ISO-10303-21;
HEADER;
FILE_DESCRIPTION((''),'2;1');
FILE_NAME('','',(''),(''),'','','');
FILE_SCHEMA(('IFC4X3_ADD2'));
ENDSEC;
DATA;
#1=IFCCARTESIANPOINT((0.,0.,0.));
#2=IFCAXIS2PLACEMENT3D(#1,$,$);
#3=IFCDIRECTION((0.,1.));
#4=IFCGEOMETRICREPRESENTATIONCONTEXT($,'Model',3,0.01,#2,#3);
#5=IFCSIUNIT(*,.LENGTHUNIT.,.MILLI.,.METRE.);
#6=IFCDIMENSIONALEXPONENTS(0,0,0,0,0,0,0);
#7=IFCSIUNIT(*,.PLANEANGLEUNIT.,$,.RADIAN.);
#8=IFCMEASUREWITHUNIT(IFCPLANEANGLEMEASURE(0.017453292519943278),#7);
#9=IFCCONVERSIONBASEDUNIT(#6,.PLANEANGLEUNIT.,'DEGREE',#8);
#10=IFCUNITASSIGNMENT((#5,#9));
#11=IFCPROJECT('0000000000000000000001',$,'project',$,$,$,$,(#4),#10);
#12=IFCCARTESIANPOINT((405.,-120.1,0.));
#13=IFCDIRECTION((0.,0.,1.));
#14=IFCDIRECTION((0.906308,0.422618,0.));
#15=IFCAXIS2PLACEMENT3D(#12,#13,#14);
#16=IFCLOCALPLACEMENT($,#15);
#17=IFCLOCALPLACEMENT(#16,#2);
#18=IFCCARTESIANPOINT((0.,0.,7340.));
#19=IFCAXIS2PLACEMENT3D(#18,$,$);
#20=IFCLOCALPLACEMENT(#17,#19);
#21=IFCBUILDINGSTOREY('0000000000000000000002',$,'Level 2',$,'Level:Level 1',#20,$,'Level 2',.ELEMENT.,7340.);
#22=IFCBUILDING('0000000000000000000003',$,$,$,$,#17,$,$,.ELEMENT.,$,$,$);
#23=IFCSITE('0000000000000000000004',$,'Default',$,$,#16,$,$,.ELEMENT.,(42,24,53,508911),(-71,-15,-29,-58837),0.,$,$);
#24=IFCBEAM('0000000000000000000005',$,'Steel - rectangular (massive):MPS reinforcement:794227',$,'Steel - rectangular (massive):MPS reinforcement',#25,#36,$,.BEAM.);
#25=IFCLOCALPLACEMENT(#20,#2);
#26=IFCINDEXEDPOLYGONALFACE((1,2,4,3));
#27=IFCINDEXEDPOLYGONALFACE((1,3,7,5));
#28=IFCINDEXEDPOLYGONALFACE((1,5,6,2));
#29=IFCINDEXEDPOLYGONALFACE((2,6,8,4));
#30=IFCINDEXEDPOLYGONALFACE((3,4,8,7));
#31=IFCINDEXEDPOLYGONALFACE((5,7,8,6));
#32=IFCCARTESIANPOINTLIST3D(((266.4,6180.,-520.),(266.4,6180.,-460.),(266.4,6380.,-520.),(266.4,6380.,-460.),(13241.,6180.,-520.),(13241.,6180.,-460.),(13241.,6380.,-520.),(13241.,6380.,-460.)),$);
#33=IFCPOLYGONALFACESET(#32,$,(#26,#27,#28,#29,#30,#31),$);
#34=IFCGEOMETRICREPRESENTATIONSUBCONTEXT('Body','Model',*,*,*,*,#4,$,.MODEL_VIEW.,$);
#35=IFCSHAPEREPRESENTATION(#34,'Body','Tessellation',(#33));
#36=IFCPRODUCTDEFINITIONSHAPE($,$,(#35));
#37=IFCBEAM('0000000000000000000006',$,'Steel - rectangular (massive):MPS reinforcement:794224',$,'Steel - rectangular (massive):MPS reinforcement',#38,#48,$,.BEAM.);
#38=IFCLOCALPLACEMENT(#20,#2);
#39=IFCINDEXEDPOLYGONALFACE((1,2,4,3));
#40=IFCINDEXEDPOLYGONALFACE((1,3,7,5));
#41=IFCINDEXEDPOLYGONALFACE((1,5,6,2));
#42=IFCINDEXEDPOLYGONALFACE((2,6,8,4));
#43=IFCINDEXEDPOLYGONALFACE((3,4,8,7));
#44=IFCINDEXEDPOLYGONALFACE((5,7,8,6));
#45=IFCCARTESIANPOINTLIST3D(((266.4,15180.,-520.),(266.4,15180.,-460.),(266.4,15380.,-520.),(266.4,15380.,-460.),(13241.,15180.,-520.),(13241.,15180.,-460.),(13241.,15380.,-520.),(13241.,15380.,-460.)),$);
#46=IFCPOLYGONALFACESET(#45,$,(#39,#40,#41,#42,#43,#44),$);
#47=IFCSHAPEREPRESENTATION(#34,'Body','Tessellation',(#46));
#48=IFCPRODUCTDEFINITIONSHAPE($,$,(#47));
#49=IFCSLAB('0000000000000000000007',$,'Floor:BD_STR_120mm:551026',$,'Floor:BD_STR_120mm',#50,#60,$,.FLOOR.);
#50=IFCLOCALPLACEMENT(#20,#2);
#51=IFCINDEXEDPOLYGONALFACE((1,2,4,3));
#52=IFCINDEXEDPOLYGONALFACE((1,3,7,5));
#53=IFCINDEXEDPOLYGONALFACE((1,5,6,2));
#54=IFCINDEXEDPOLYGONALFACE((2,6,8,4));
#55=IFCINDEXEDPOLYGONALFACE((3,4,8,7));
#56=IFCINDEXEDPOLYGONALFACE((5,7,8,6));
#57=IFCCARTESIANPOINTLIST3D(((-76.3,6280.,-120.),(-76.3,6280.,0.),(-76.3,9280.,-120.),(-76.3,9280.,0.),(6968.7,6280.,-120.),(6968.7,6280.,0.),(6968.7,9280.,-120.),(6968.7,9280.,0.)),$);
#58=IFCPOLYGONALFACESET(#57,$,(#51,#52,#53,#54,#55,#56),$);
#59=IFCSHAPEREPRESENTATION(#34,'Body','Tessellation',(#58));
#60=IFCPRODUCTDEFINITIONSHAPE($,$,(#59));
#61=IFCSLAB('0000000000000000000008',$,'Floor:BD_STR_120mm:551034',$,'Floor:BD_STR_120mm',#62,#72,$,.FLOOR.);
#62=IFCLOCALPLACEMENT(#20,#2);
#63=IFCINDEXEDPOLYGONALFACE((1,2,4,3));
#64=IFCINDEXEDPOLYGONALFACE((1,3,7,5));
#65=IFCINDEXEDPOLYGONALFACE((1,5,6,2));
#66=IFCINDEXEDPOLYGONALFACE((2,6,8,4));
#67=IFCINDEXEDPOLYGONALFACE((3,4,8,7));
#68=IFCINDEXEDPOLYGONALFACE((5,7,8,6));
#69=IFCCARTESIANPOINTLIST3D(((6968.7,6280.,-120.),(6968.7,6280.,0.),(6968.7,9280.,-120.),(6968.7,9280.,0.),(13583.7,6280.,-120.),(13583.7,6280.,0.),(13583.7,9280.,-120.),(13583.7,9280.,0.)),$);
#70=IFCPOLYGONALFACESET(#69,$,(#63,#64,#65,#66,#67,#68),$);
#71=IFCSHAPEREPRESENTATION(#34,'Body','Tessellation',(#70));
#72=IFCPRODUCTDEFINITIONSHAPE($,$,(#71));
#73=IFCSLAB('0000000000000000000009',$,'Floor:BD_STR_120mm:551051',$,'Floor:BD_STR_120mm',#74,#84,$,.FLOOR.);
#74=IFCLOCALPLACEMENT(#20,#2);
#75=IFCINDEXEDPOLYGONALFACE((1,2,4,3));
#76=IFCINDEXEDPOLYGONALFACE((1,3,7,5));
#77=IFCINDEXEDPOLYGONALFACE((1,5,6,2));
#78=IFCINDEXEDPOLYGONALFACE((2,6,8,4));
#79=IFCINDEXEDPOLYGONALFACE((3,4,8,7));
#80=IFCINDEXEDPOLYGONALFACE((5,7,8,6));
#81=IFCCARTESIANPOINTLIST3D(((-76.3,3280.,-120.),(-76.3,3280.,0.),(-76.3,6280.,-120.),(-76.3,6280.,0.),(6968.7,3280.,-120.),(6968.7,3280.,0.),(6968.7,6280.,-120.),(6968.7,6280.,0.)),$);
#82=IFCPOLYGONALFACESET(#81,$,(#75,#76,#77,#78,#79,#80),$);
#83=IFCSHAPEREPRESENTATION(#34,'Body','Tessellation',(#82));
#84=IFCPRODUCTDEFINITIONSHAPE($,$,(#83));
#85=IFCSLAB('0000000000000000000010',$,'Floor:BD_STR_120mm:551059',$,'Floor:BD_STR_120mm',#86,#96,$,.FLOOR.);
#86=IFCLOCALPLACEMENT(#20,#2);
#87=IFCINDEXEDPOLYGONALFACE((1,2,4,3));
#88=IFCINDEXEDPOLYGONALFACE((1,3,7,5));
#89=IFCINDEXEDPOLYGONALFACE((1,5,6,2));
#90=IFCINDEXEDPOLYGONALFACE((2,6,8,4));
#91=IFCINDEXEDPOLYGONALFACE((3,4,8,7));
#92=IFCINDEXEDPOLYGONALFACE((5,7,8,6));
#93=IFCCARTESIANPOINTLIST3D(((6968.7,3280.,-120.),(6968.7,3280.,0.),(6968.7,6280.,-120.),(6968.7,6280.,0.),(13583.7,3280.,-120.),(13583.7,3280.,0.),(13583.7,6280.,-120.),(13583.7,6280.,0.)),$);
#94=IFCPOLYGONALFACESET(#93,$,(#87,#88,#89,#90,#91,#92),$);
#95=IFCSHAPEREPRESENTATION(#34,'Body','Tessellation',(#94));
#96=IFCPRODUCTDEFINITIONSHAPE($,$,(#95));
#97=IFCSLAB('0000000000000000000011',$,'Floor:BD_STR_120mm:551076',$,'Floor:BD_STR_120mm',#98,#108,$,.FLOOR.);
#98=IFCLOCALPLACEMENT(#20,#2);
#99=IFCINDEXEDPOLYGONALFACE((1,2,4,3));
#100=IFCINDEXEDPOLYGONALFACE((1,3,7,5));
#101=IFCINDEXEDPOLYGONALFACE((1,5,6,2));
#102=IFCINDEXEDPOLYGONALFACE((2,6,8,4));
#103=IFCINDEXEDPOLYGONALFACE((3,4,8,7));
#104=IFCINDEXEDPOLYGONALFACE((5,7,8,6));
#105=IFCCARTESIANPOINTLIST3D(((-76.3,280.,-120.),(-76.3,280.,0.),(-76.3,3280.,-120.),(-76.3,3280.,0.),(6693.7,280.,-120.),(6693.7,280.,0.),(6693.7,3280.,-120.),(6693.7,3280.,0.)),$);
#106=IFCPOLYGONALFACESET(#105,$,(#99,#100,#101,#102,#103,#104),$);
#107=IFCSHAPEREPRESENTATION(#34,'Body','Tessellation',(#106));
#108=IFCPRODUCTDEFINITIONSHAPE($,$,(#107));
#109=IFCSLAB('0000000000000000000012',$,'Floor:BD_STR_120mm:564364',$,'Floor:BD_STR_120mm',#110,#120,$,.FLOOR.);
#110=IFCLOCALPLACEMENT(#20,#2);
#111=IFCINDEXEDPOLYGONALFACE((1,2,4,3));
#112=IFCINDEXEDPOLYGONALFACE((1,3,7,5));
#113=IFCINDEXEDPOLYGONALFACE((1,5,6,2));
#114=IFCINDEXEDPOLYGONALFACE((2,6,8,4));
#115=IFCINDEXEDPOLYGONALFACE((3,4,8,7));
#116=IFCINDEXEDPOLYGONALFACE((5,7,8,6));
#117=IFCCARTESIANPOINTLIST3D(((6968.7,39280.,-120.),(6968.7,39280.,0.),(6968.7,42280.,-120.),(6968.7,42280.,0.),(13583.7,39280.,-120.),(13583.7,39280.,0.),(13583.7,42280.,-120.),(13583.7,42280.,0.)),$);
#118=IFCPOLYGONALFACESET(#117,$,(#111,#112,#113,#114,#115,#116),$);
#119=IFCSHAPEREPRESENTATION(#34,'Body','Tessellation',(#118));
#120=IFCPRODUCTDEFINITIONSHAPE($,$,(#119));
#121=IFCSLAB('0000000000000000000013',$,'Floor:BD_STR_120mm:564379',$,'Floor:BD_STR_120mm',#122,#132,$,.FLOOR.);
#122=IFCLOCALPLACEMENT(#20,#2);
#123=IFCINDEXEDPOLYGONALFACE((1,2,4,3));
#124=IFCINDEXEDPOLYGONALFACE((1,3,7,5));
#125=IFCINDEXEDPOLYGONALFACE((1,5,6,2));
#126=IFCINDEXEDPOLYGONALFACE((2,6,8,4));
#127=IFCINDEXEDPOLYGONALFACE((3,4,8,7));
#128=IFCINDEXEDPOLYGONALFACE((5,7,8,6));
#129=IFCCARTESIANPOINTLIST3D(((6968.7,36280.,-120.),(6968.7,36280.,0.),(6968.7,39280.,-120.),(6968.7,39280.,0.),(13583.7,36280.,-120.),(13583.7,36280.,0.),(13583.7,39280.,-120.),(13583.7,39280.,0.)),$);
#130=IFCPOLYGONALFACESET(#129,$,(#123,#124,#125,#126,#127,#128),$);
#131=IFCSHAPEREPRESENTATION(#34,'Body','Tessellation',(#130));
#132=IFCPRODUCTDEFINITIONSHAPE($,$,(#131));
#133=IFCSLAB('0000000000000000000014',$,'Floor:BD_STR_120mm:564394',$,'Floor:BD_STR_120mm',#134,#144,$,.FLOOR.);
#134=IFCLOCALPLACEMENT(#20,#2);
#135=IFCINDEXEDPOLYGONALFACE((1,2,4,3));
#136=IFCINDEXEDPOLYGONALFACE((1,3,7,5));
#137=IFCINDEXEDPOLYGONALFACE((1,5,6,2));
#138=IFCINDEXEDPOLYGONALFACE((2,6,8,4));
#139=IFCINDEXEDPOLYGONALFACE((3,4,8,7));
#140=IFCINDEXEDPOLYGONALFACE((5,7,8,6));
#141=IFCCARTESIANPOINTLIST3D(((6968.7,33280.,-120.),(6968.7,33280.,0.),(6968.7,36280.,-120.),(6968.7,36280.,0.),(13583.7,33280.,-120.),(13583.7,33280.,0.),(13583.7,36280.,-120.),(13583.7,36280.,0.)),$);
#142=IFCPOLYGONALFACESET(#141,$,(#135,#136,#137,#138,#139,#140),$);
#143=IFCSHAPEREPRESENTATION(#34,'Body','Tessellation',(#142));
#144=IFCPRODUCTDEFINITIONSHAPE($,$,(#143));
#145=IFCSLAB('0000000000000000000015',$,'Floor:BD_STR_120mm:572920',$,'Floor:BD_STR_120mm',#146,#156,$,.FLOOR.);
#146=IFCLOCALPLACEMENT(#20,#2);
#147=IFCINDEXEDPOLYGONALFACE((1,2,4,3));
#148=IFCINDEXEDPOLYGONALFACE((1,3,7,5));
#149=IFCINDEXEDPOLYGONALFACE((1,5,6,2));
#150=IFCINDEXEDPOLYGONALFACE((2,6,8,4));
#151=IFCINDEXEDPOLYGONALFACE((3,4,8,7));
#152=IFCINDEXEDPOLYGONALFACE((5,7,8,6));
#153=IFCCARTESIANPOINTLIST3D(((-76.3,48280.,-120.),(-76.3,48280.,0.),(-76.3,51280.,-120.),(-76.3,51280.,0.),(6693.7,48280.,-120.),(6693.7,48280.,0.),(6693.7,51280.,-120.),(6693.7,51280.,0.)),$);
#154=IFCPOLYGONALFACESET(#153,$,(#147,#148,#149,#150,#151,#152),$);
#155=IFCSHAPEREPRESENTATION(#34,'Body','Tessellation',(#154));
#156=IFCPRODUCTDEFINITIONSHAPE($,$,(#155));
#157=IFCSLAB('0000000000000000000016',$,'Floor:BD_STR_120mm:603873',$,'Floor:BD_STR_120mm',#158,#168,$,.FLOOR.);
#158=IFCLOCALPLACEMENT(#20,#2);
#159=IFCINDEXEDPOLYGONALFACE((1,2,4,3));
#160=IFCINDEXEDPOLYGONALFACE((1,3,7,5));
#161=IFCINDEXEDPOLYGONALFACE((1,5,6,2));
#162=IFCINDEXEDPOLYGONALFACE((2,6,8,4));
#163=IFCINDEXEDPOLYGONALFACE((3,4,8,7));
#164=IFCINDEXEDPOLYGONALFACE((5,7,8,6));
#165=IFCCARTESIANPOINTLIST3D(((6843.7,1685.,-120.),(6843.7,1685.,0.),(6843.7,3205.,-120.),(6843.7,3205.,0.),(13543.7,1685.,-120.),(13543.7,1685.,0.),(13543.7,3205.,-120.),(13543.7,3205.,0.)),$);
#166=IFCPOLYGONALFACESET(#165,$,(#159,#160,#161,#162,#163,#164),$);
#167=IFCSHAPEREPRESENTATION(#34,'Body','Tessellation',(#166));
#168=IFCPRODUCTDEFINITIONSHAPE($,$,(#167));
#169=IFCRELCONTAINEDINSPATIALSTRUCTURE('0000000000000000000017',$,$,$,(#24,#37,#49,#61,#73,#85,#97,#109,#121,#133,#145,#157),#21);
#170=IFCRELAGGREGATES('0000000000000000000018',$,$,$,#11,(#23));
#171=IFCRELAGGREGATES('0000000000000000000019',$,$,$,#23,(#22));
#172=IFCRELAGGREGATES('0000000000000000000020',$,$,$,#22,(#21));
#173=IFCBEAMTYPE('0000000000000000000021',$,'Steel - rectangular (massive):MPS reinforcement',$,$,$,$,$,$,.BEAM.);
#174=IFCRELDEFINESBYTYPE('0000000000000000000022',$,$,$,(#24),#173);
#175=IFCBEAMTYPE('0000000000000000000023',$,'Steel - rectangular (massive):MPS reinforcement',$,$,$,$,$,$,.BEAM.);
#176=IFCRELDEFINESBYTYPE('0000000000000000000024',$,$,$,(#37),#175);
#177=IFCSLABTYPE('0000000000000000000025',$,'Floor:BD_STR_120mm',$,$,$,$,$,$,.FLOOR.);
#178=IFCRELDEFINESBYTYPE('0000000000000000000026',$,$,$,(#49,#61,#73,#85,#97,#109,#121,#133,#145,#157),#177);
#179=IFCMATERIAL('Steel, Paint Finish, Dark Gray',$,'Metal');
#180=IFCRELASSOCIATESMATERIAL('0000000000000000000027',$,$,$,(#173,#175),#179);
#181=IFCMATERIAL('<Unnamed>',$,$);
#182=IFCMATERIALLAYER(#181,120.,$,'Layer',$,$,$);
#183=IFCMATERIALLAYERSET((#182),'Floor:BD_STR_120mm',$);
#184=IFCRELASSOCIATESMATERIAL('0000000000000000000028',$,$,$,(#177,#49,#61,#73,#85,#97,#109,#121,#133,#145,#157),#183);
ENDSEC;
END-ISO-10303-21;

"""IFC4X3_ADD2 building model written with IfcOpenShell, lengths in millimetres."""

from ifc_helpers import new_model, entity, si_unit, converted_unit, direction, frame, frame_2d, origin, origin_2d_with_axis, place, context, subcontext, project, spatial, rectangle, extrude, source, transform, mapped, material, layer, layer_set, layer_usage, material_profile, profile_set, type_object, type_shapes, element, save


model = new_model("IFC4X3_ADD2")

# Units and contexts
model_context = context("Model", 3, precision=0.01, world=origin(), true_north=direction((0.0, 1.0)))
body_context = subcontext(model_context, "Body", "Model", "MODEL_VIEW")
ifc_project = project(units=[si_unit("LENGTHUNIT", "METRE", prefix="MILLI"), converted_unit("PLANEANGLEUNIT", "DEGREE", entity("IfcPlaneAngleMeasure", 0.017453292519943278), si_unit("PLANEANGLEUNIT", "RADIAN"), dimensions=[0, 0, 0, 0, 0, 0, 0])], contexts=[model_context])

# Site, building, storey
site_placement = place(None, frame((405.0, -120.1, 0.0), z_axis=(0.0, 0.0, 1.0), x_axis=(0.906308, 0.422618, 0.0)))
site = spatial("IfcSite", under=ifc_project, at=site_placement, Name="Default", CompositionType="ELEMENT", RefLatitude=(42, 24, 53, 508911), RefLongitude=(-71, -15, -29, -58837), RefElevation=0.0)
building_placement = place(site_placement, origin())
building = spatial("IfcBuilding", under=site, at=building_placement, CompositionType="ELEMENT")
storey_placement = place(building_placement, frame((0.0, 0.0, 7340.0)))
storey = spatial("IfcBuildingStorey", under=building, at=storey_placement, Name="Level 2", ObjectType="Level:Level 1", LongName="Level 2", CompositionType="ELEMENT", Elevation=7340.0)

# Beams
ifc_material_1 = material(Name="Steel, Paint Finish, Dark Gray", Category="Metal")
ifc_material_profile_1 = material_profile(ifc_material_1, rectangle(XDim=12974.6, YDim=200.0, at=origin_2d_with_axis()), Name="MPS reinforcement")
ifc_profile_set_1 = profile_set([ifc_material_profile_1], Name="MPS reinforcement")
beam_type_1 = type_object("IfcBeamType", Name="Steel - rectangular (massive):MPS reinforcement", PredefinedType="BEAM", material=ifc_profile_set_1)
shared_shape_1 = source(origin(), body_context, "Body", "SweptSolid", [
    extrude(rectangle(XDim=12974.6, YDim=200.0, at=origin_2d_with_axis()), frame((0.0, 0.0, -30.0), z_axis=(0.0, 0.0, 1.0), x_axis=(-1.0, 0.0, 0.0)), (0.0, 0.0, 1.0), 60.0),
])
type_shapes(beam_type_1, [shared_shape_1])
beam_1_placement = place(storey_placement, frame((6753.7, 6280.0, -490.0), z_axis=(0.0, 0.0, 1.0), x_axis=(-1.0, 0.0, 0.0)))
element("IfcBeam", 1, at=beam_1_placement, inside=storey, type_object=beam_type_1, Name="Steel - rectangular (massive):MPS reinforcement:794227", ObjectType="Steel - rectangular (massive):MPS reinforcement", PredefinedType="BEAM", context=body_context, shape_type="MappedRepresentation", body=[
    mapped(shared_shape_1, transform((0.0, 0.0, 0.0), scale=1.0)),
])
beam_type_2 = type_object("IfcBeamType", Name="Steel - rectangular (massive):MPS reinforcement", PredefinedType="BEAM", material=ifc_profile_set_1)
shared_shape_2 = source(origin(), body_context, "Body", "SweptSolid", [
    extrude(rectangle(XDim=12974.6, YDim=200.0, at=origin_2d_with_axis()), frame((-0.5, 0.0, -30.0), z_axis=(0.0, 0.0, 1.0), x_axis=(-1.0, 0.0, 0.0)), (0.0, 0.0, 1.0), 60.0),
])
type_shapes(beam_type_2, [shared_shape_2])
beam_2_placement = place(storey_placement, frame((6754.2, 15280.0, -490.0)))
element("IfcBeam", 2, at=beam_2_placement, inside=storey, type_object=beam_type_2, Name="Steel - rectangular (massive):MPS reinforcement:794224", ObjectType="Steel - rectangular (massive):MPS reinforcement", PredefinedType="BEAM", context=body_context, shape_type="MappedRepresentation", body=[
    mapped(shared_shape_2, transform((0.0, 0.0, 0.0), scale=1.0)),
])

# Slabs
ifc_material_2 = material(Name="<Unnamed>")
ifc_layer_1 = layer(ifc_material_2, 120.0, Name="Layer")
ifc_layer_set_1 = layer_set([ifc_layer_1], Name="Floor:BD_STR_120mm")
ifc_layer_usage_1 = layer_usage(ifc_layer_set_1, "AXIS3", "POSITIVE", 0.0)
slab_type_1 = type_object("IfcSlabType", Name="Floor:BD_STR_120mm", PredefinedType="FLOOR", material=ifc_layer_set_1)
slab_1_placement = place(storey_placement, origin())
element("IfcSlab", 3, at=slab_1_placement, inside=storey, type_object=slab_type_1, material=ifc_layer_usage_1, Name="Floor:BD_STR_120mm:551026", ObjectType="Floor:BD_STR_120mm", PredefinedType="FLOOR", context=body_context, shape_type="SweptSolid", body=[
    extrude(rectangle(XDim=3000.0, YDim=7045.0, at=origin_2d_with_axis()), frame((3446.2, 7780.0, 0.0), z_axis=(0.0, 0.0, -1.0), x_axis=(0.0, 1.0, 0.0)), (0.0, 0.0, 1.0), 120.0),
])
ifc_layer_usage_2 = layer_usage(ifc_layer_set_1, "AXIS3", "POSITIVE", 0.0)
slab_2_placement = place(storey_placement, origin())
element("IfcSlab", 4, at=slab_2_placement, inside=storey, type_object=slab_type_1, material=ifc_layer_usage_2, Name="Floor:BD_STR_120mm:551034", ObjectType="Floor:BD_STR_120mm", PredefinedType="FLOOR", context=body_context, shape_type="SweptSolid", body=[
    extrude(rectangle(XDim=3000.0, YDim=6615.0, at=frame_2d((0.0, 0.0), x_axis=(1.0, 0.0))), frame((10276.2, 7780.0, 0.0), z_axis=(0.0, 0.0, -1.0), x_axis=(0.0, 1.0, 0.0)), (0.0, 0.0, 1.0), 120.0),
])
ifc_layer_usage_3 = layer_usage(ifc_layer_set_1, "AXIS3", "POSITIVE", 0.0)
slab_3_placement = place(storey_placement, origin())
element("IfcSlab", 5, at=slab_3_placement, inside=storey, type_object=slab_type_1, material=ifc_layer_usage_3, Name="Floor:BD_STR_120mm:551051", ObjectType="Floor:BD_STR_120mm", PredefinedType="FLOOR", context=body_context, shape_type="SweptSolid", body=[
    extrude(rectangle(XDim=3000.0, YDim=7045.0, at=origin_2d_with_axis()), frame((3446.2, 4780.0, 0.0), z_axis=(0.0, 0.0, -1.0), x_axis=(0.0, 1.0, 0.0)), (0.0, 0.0, 1.0), 120.0),
])
ifc_layer_usage_4 = layer_usage(ifc_layer_set_1, "AXIS3", "POSITIVE", 0.0)
slab_4_placement = place(storey_placement, origin())
element("IfcSlab", 6, at=slab_4_placement, inside=storey, type_object=slab_type_1, material=ifc_layer_usage_4, Name="Floor:BD_STR_120mm:551059", ObjectType="Floor:BD_STR_120mm", PredefinedType="FLOOR", context=body_context, shape_type="SweptSolid", body=[
    extrude(rectangle(XDim=3000.0, YDim=6615.0, at=frame_2d((0.0, 0.0), x_axis=(1.0, 0.0))), frame((10276.2, 4780.0, 0.0), z_axis=(0.0, 0.0, -1.0), x_axis=(0.0, 1.0, 0.0)), (0.0, 0.0, 1.0), 120.0),
])
ifc_layer_usage_5 = layer_usage(ifc_layer_set_1, "AXIS3", "POSITIVE", 0.0)
slab_5_placement = place(storey_placement, origin())
element("IfcSlab", 7, at=slab_5_placement, inside=storey, type_object=slab_type_1, material=ifc_layer_usage_5, Name="Floor:BD_STR_120mm:551076", ObjectType="Floor:BD_STR_120mm", PredefinedType="FLOOR", context=body_context, shape_type="SweptSolid", body=[
    extrude(rectangle(XDim=3000.0, YDim=6770.0, at=frame_2d((0.0, 0.0), x_axis=(1.0, 0.0))), frame((3308.7, 1780.0, 0.0), z_axis=(0.0, 0.0, -1.0), x_axis=(0.0, 1.0, 0.0)), (0.0, 0.0, 1.0), 120.0),
])
ifc_layer_usage_6 = layer_usage(ifc_layer_set_1, "AXIS3", "POSITIVE", 0.0)
slab_6_placement = place(storey_placement, origin())
element("IfcSlab", 8, at=slab_6_placement, inside=storey, type_object=slab_type_1, material=ifc_layer_usage_6, Name="Floor:BD_STR_120mm:564364", ObjectType="Floor:BD_STR_120mm", PredefinedType="FLOOR", context=body_context, shape_type="SweptSolid", body=[
    extrude(rectangle(XDim=3000.0, YDim=6615.0, at=frame_2d((0.0, 0.0), x_axis=(1.0, 0.0))), frame((10276.2, 40780.0, 0.0), z_axis=(0.0, 0.0, -1.0), x_axis=(0.0, 1.0, 0.0)), (0.0, 0.0, 1.0), 120.0),
])
ifc_layer_usage_7 = layer_usage(ifc_layer_set_1, "AXIS3", "POSITIVE", 0.0)
slab_7_placement = place(storey_placement, origin())
element("IfcSlab", 9, at=slab_7_placement, inside=storey, type_object=slab_type_1, material=ifc_layer_usage_7, Name="Floor:BD_STR_120mm:564379", ObjectType="Floor:BD_STR_120mm", PredefinedType="FLOOR", context=body_context, shape_type="SweptSolid", body=[
    extrude(rectangle(XDim=3000.0, YDim=6615.0, at=frame_2d((0.0, 0.0), x_axis=(1.0, 0.0))), frame((10276.2, 37780.0, 0.0), z_axis=(0.0, 0.0, -1.0), x_axis=(0.0, 1.0, 0.0)), (0.0, 0.0, 1.0), 120.0),
])
ifc_layer_usage_8 = layer_usage(ifc_layer_set_1, "AXIS3", "POSITIVE", 0.0)
slab_8_placement = place(storey_placement, origin())
element("IfcSlab", 10, at=slab_8_placement, inside=storey, type_object=slab_type_1, material=ifc_layer_usage_8, Name="Floor:BD_STR_120mm:564394", ObjectType="Floor:BD_STR_120mm", PredefinedType="FLOOR", context=body_context, shape_type="SweptSolid", body=[
    extrude(rectangle(XDim=3000.0, YDim=6615.0, at=frame_2d((0.0, 0.0), x_axis=(1.0, 0.0))), frame((10276.2, 34780.0, 0.0), z_axis=(0.0, 0.0, -1.0), x_axis=(0.0, 1.0, 0.0)), (0.0, 0.0, 1.0), 120.0),
])
ifc_layer_usage_9 = layer_usage(ifc_layer_set_1, "AXIS3", "POSITIVE", 0.0)
slab_9_placement = place(storey_placement, origin())
element("IfcSlab", 11, at=slab_9_placement, inside=storey, type_object=slab_type_1, material=ifc_layer_usage_9, Name="Floor:BD_STR_120mm:572920", ObjectType="Floor:BD_STR_120mm", PredefinedType="FLOOR", context=body_context, shape_type="SweptSolid", body=[
    extrude(rectangle(XDim=3000.0, YDim=6770.0, at=origin_2d_with_axis()), frame((3308.7, 49780.0, 0.0), z_axis=(0.0, 0.0, -1.0), x_axis=(0.0, 1.0, 0.0)), (0.0, 0.0, 1.0), 120.0),
])
ifc_layer_usage_10 = layer_usage(ifc_layer_set_1, "AXIS3", "POSITIVE", 0.0)
slab_10_placement = place(storey_placement, origin())
element("IfcSlab", 12, at=slab_10_placement, inside=storey, type_object=slab_type_1, material=ifc_layer_usage_10, Name="Floor:BD_STR_120mm:603873", ObjectType="Floor:BD_STR_120mm", PredefinedType="FLOOR", context=body_context, shape_type="SweptSolid", body=[
    extrude(rectangle(XDim=1520.0, YDim=6700.0, at=frame_2d((0.0, 0.0), x_axis=(1.0, 0.0))), frame((10193.7, 2445.0, 0.0), z_axis=(0.0, 0.0, -1.0), x_axis=(0.0, 1.0, 0.0)), (0.0, 0.0, 1.0), 120.0),
])

save(model, "model.ifc")
